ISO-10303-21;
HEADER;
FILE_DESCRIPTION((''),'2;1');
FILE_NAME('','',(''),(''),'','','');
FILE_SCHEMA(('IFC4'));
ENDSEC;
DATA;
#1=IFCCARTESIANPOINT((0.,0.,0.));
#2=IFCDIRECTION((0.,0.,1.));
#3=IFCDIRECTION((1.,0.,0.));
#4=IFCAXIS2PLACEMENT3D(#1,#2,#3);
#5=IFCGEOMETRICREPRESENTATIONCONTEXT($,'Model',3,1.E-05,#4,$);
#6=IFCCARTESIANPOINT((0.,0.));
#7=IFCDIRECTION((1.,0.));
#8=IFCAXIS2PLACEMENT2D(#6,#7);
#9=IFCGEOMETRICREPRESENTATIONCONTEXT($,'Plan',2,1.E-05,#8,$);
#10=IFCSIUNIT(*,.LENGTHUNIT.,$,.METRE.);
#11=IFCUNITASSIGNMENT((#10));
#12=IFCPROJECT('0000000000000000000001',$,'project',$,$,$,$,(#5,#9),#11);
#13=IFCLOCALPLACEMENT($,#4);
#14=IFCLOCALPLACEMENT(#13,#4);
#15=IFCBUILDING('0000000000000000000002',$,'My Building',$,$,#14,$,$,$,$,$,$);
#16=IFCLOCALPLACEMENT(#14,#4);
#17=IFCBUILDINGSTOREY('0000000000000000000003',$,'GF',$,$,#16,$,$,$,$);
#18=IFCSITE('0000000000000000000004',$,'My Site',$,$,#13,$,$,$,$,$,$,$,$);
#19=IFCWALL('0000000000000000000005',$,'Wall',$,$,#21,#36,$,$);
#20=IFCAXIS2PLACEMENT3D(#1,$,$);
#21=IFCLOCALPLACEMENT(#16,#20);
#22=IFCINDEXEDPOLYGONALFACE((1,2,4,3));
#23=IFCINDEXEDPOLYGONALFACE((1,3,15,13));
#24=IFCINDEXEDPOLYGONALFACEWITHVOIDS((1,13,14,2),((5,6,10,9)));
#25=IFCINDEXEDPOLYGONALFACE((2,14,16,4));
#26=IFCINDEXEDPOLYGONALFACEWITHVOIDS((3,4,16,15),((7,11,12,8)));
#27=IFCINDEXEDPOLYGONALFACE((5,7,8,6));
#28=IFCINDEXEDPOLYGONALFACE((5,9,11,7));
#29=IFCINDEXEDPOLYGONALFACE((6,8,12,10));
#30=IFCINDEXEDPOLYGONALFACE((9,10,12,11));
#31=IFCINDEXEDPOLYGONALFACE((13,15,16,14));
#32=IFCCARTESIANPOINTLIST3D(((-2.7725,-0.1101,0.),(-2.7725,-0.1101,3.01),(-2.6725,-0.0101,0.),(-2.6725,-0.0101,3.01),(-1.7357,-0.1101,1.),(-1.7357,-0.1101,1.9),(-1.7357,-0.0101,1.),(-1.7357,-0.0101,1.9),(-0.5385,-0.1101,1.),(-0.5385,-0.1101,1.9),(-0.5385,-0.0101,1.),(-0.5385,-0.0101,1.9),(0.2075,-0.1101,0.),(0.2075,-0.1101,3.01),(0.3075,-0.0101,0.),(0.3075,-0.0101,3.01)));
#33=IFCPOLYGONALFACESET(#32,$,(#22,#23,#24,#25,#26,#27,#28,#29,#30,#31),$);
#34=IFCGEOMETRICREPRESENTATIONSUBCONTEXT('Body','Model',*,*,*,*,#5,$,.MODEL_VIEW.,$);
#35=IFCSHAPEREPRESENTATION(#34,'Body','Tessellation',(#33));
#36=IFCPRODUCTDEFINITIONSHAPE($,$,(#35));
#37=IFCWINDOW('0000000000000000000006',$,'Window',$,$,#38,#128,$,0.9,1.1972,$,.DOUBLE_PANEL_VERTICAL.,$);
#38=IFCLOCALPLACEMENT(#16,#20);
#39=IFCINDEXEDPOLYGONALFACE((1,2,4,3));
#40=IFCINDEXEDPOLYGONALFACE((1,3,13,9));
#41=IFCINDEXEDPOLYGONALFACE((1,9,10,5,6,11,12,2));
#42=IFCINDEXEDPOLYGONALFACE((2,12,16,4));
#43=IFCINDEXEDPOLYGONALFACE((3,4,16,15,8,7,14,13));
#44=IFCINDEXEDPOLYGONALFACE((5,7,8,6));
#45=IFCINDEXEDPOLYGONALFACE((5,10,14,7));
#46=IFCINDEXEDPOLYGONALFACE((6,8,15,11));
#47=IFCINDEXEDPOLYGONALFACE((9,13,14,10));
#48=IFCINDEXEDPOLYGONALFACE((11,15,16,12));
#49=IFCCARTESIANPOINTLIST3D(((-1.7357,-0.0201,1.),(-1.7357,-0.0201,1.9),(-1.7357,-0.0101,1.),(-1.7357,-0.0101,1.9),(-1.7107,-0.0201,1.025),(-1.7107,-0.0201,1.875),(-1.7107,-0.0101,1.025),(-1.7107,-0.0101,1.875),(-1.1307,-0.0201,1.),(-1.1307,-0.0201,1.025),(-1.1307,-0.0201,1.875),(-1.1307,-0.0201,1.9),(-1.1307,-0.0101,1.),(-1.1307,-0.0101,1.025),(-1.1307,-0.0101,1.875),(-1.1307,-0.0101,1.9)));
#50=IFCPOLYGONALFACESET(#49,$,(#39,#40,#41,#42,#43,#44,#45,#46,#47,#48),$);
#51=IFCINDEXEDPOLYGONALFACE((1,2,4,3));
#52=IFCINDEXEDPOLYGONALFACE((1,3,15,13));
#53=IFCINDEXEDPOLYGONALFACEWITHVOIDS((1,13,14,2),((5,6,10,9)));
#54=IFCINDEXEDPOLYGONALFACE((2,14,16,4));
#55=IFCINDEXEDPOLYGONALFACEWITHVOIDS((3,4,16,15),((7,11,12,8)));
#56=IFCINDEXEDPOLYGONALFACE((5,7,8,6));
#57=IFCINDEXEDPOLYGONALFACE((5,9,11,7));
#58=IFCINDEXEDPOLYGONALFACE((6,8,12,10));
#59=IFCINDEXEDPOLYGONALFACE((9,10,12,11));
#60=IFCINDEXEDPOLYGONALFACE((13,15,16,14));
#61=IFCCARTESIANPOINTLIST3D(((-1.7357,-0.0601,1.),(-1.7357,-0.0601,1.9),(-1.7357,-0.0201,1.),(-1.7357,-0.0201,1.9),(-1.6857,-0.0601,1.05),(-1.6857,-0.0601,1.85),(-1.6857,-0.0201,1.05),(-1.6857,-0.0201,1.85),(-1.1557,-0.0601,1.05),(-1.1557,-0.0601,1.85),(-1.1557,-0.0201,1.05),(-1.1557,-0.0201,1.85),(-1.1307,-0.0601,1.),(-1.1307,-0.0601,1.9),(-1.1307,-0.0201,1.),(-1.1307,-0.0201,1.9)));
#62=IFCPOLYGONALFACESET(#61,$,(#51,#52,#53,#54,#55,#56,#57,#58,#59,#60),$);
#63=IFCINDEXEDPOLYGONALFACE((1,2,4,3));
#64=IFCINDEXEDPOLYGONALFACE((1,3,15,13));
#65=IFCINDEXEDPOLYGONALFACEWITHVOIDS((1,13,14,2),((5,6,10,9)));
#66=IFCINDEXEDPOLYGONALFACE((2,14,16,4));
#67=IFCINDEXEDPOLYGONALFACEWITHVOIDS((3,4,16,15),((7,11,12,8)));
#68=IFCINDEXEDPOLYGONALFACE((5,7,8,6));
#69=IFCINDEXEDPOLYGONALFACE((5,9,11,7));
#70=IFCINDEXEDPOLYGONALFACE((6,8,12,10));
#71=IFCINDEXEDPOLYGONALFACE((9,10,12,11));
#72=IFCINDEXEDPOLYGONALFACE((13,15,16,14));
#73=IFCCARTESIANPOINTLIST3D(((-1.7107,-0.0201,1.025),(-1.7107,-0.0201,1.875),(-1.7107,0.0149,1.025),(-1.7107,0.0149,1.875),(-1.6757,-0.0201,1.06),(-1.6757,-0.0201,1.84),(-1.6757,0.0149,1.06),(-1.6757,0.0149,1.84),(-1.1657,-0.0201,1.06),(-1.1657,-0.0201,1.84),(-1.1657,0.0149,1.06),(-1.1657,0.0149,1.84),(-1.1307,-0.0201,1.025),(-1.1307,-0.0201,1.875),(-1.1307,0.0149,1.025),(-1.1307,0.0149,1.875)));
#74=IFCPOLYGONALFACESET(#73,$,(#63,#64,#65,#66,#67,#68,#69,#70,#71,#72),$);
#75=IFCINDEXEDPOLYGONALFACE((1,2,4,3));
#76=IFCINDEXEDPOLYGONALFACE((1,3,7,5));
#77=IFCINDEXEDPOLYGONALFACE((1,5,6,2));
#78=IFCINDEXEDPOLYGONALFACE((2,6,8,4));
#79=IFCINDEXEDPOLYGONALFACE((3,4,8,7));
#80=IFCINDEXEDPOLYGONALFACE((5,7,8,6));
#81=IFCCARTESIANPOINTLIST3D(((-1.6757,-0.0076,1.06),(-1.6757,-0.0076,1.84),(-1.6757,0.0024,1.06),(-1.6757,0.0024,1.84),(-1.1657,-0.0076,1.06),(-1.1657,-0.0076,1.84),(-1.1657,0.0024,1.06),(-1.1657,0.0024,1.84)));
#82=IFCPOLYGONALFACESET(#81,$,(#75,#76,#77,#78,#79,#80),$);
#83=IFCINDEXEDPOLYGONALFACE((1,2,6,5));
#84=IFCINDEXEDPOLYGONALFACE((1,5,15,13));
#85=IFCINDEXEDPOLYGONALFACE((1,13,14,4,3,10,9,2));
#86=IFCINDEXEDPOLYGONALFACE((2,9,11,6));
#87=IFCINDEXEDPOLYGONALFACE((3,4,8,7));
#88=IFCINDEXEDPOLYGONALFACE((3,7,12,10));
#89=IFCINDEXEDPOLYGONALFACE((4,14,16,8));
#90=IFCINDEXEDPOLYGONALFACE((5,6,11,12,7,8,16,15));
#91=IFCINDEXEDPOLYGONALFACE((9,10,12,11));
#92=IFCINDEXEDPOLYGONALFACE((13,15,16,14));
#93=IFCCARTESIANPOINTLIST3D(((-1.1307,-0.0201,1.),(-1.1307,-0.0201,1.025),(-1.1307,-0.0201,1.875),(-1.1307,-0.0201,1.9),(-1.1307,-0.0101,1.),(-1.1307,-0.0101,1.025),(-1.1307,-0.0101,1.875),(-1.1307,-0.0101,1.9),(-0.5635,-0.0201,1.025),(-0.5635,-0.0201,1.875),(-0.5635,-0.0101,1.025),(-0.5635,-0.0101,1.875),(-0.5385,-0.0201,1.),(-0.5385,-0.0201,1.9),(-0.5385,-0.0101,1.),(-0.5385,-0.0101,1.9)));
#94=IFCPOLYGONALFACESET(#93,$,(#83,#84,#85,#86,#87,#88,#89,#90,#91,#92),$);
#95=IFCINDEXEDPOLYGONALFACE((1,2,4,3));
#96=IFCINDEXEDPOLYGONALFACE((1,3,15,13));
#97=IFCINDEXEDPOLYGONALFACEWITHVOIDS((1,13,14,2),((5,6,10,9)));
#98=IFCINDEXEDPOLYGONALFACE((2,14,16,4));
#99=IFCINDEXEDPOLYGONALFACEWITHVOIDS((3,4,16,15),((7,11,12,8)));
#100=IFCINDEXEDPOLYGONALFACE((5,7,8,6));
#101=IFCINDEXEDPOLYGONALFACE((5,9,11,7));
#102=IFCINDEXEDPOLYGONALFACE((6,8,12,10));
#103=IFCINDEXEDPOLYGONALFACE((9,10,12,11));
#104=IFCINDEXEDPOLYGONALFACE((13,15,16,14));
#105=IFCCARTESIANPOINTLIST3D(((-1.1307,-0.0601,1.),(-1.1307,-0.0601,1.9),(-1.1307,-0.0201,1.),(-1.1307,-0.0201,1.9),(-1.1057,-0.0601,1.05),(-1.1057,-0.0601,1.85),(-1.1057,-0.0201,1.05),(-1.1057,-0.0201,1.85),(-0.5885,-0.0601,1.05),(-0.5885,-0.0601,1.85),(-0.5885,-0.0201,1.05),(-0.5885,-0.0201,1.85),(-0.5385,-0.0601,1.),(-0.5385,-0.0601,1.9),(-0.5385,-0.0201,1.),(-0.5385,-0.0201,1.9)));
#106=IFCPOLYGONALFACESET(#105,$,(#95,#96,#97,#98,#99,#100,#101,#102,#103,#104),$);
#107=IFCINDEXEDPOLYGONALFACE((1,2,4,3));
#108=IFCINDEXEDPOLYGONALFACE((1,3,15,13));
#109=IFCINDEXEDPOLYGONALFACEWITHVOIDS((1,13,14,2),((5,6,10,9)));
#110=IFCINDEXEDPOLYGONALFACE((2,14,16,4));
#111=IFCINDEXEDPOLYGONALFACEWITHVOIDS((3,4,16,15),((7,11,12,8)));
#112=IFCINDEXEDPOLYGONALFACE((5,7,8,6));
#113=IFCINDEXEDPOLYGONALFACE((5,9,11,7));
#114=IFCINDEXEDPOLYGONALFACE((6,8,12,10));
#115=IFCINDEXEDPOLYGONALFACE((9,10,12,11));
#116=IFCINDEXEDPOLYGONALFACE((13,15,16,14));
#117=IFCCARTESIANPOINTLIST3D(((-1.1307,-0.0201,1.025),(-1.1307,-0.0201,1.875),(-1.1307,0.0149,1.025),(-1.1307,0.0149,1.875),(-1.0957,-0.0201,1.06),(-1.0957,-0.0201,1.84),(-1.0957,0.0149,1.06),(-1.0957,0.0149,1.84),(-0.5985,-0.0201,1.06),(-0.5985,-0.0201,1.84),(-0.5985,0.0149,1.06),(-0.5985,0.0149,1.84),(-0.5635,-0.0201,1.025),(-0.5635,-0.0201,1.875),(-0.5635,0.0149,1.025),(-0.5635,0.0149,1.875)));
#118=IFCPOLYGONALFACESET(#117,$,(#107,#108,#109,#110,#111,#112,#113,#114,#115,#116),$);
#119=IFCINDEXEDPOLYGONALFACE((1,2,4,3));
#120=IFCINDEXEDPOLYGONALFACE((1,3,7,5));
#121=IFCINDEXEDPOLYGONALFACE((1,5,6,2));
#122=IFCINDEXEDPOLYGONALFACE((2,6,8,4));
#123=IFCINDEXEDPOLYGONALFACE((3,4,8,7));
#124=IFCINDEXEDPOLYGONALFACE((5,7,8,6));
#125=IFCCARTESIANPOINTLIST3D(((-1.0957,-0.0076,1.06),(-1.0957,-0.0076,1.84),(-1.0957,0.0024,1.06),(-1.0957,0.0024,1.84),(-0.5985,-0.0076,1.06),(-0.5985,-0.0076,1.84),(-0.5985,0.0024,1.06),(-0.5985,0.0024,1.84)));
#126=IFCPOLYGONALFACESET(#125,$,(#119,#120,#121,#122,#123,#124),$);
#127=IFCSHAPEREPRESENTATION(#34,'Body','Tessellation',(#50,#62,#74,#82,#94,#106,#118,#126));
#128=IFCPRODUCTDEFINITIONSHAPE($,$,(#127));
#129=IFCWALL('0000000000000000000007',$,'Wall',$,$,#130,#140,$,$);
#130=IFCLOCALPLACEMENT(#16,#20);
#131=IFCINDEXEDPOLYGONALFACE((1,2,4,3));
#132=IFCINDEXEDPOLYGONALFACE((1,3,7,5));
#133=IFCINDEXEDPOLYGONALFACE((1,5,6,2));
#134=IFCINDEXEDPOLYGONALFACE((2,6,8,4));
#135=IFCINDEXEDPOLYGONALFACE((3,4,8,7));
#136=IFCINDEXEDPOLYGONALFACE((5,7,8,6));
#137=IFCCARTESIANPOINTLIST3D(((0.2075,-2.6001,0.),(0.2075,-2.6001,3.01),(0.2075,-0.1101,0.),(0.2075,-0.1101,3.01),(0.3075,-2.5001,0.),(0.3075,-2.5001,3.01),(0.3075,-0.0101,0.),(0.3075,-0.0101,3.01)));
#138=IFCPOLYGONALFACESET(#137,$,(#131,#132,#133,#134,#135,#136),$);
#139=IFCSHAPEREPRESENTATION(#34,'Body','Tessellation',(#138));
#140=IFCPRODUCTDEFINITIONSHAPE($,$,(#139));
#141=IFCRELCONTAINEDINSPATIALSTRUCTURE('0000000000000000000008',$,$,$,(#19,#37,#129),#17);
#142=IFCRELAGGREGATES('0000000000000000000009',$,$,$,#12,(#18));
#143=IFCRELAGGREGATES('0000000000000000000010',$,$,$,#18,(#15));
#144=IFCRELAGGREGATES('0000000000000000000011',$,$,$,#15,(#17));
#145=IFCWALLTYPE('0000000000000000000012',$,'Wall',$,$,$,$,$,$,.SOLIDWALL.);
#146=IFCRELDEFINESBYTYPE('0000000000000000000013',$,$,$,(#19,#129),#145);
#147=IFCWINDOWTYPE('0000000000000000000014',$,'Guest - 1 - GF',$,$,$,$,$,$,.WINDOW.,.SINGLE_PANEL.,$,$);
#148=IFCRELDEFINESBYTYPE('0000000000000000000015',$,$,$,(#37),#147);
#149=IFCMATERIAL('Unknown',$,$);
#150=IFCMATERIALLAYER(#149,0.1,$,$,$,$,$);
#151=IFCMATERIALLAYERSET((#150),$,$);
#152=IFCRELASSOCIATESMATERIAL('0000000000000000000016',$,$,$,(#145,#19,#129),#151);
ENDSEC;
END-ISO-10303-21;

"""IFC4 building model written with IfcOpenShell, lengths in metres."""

from ifc_helpers import new_model, entity, si_unit, frame, origin_with_axes, origin_2d_with_axis, place, context, subcontext, project, spatial, line, indexed_curve, outline, extrude, shape, source, transform, mapped, material, layer, layer_set, layer_usage, type_object, type_shapes, element, fill, save


model = new_model("IFC4")

# Units and contexts
model_context = context("Model", 3, precision=1e-05, world=origin_with_axes())
plan_context = context("Plan", 2, precision=1e-05, world=origin_2d_with_axis())
body_context_1 = subcontext(model_context, "Body", "Model", "MODEL_VIEW")
body_context_2 = subcontext(plan_context, "Body", "Plan", "PLAN_VIEW")
ifc_project = project(units=[si_unit("LENGTHUNIT", "METRE")], contexts=[model_context, plan_context])

# Site, building, storey
site_placement = place(None, origin_with_axes())
site = spatial("IfcSite", under=ifc_project, at=site_placement, Name="My Site")
building_placement = place(site_placement, origin_with_axes())
building = spatial("IfcBuilding", under=site, at=building_placement, Name="My Building")
storey_placement = place(building_placement, origin_with_axes())
storey = spatial("IfcBuildingStorey", under=building, at=storey_placement, Name="GF")

# Shared definitions
ifc_material_1 = material(Name="Unknown")

# Shared definitions
ifc_layer_1 = layer(ifc_material_1, 0.1)
ifc_layer_set_1 = layer_set([ifc_layer_1])
wall_type = type_object("IfcWallType", Name="Wall", PredefinedType="SOLIDWALL", material=ifc_layer_set_1)

# Wall, opening, window
ifc_layer_usage_1 = layer_usage(ifc_layer_set_1, "AXIS2", "POSITIVE", 0.0)
wall_1_placement = place(storey_placement, frame((-2.7725, -0.1101, 0.0), z_axis=(0.0, 0.0, 1.0), x_axis=(1.0, 0.0, 0.0)))
wall_1 = element("IfcWall", 1, at=wall_1_placement, inside=storey, type_object=wall_type, material=ifc_layer_usage_1, Name="Wall", context=body_context_1, shape_type="SweptSolid", body=[
    extrude(outline(indexed_curve([(0.0, 0.0), (0.1, 0.1), (3.08, 0.1), (2.98, 0.0)], segments=[line(1, 2, 3, 4, 1)])), origin_with_axes(), (0.0, 0.0, 1.0), 3.01),
])
shared_shape_1 = source(origin_with_axes(), body_context_1, "Body", "SweptSolid", [
    extrude(outline(indexed_curve([(0.0, 0.0), (1.1972, 0.0), (1.1972, 0.9), (0.0, 0.9)], segments=[line(1, 2, 3, 4, 1)])), frame((0.0, -0.6, 0.0), z_axis=(0.0, -1.0, 0.0), x_axis=(1.0, 0.0, 0.0)), (0.0, 0.0, -1.0), 1.2),
])
opening_1_placement = place(wall_1_placement, frame((1.0369, 0.0, 1.0), z_axis=(0.0, 0.0, 1.0), x_axis=(1.0, 0.0, 0.0)))
opening_1 = element("IfcOpeningElement", 2, at=opening_1_placement, cuts=wall_1, PredefinedType="OPENING", context=body_context_1, shape_type="MappedRepresentation", body=[
    mapped(shared_shape_1, transform((0.0, 0.0, 0.0), x_axis=(1.0, 0.0, 0.0), y_axis=(0.0, 1.0, 0.0), z_axis=(0.0, 0.0, 1.0), scale=1.0)),
])
window_type_1 = type_object("IfcWindowType", Name="Guest - 1 - GF", PartitioningType="SINGLE_PANEL", PredefinedType="WINDOW")
shared_shape_2 = source(origin_with_axes(), body_context_1, "Body", "SweptSolid", [
    extrude(outline(indexed_curve([(0.605, 0.0), (0.0, 0.0), (0.0, 0.9), (0.605, 0.9), (0.605, 0.875), (0.025, 0.875), (0.025, 0.025), (0.605, 0.025)], segments=[line(1, 2, 3, 4, 5, 6, 7, 8, 1)])), frame((0.0, 0.09, 0.0), z_axis=(0.0, -1.0, 0.0), x_axis=(1.0, 0.0, 0.0)), (0.0, 0.0, -1.0), 0.01),
    extrude(outline(indexed_curve([(0.0, 0.0), (0.605, 0.0), (0.605, 0.9), (0.0, 0.9)], segments=[line(1, 2, 3, 4, 1)]), holes=[indexed_curve([(0.05, 0.05), (0.58, 0.05), (0.58, 0.85), (0.05, 0.85)], segments=[line(1, 2, 3, 4, 1)])]), frame((0.0, 0.05, 0.0), z_axis=(0.0, -1.0, 0.0), x_axis=(1.0, 0.0, 0.0)), (0.0, 0.0, -1.0), 0.04),
    extrude(outline(indexed_curve([(0.0, 0.0), (0.58, 0.0), (0.58, 0.85), (0.0, 0.85)], segments=[line(1, 2, 3, 4, 1)]), holes=[indexed_curve([(0.035, 0.035), (0.545, 0.035), (0.545, 0.815), (0.035, 0.815)], segments=[line(1, 2, 3, 4, 1)])]), frame((0.025, 0.09, 0.025), z_axis=(0.0, -1.0, 0.0), x_axis=(1.0, 0.0, 0.0)), (0.0, 0.0, -1.0), 0.035),
    extrude(outline(indexed_curve([(0.035, 0.035), (0.545, 0.035), (0.545, 0.815), (0.035, 0.815)], segments=[line(1, 2, 3, 4, 1)])), frame((0.025, 0.1025, 0.025), z_axis=(0.0, -1.0, 0.0), x_axis=(1.0, 0.0, 0.0)), (0.0, 0.0, -1.0), 0.01),
    extrude(outline(indexed_curve([(0.0, 0.9), (0.5922, 0.9), (0.5922, 0.0), (0.0, 0.0), (0.0, 0.025), (0.5672, 0.025), (0.5672, 0.875), (0.0, 0.875)], segments=[line(1, 2, 3, 4, 5, 6, 7, 8, 1)])), frame((0.605, 0.09, 0.0), z_axis=(0.0, -1.0, 0.0), x_axis=(1.0, 0.0, 0.0)), (0.0, 0.0, -1.0), 0.01),
    extrude(outline(indexed_curve([(0.0, 0.0), (0.5922, 0.0), (0.5922, 0.9), (0.0, 0.9)], segments=[line(1, 2, 3, 4, 1)]), holes=[indexed_curve([(0.025, 0.05), (0.5422, 0.05), (0.5422, 0.85), (0.025, 0.85)], segments=[line(1, 2, 3, 4, 1)])]), frame((0.605, 0.05, 0.0), z_axis=(0.0, -1.0, 0.0), x_axis=(1.0, 0.0, 0.0)), (0.0, 0.0, -1.0), 0.04),
    extrude(outline(indexed_curve([(0.0, 0.0), (0.5672, 0.0), (0.5672, 0.85), (0.0, 0.85)], segments=[line(1, 2, 3, 4, 1)]), holes=[indexed_curve([(0.035, 0.035), (0.5322, 0.035), (0.5322, 0.815), (0.035, 0.815)], segments=[line(1, 2, 3, 4, 1)])]), frame((0.605, 0.09, 0.025), z_axis=(0.0, -1.0, 0.0), x_axis=(1.0, 0.0, 0.0)), (0.0, 0.0, -1.0), 0.035),
    extrude(outline(indexed_curve([(0.035, 0.035), (0.5322, 0.035), (0.5322, 0.815), (0.035, 0.815)], segments=[line(1, 2, 3, 4, 1)])), frame((0.605, 0.1025, 0.025), z_axis=(0.0, -1.0, 0.0), x_axis=(1.0, 0.0, 0.0)), (0.0, 0.0, -1.0), 0.01),
])
shared_shape_3 = source(origin_with_axes(), body_context_2, "Body", "Curve2D", [
    entity("IfcIndexedPolyCurve", entity("IfcCartesianPointList2D", [[0.05, 0.05], [0.58, 0.05]])),
    entity("IfcIndexedPolyCurve", entity("IfcCartesianPointList2D", [[0.0, 0.1], [0.025, 0.1], [0.025, 0.09], [0.05, 0.09], [0.05, 0.05], [0.0, 0.05]]), [entity("IfcLineIndex", [1, 2, 3, 4, 5, 6, 1])]),
    entity("IfcIndexedPolyCurve", entity("IfcCartesianPointList2D", [[0.605, 0.1], [0.605, 0.1], [0.605, 0.09], [0.58, 0.09], [0.58, 0.05], [0.605, 0.05]])),
    entity("IfcIndexedPolyCurve", entity("IfcCartesianPointList2D", [[0.025, 0.09], [0.06, 0.09], [0.06, 0.125], [0.025, 0.125]]), [entity("IfcLineIndex", [1, 2, 3, 4, 1])]),
    entity("IfcIndexedPolyCurve", entity("IfcCartesianPointList2D", [[0.605, 0.09], [0.57, 0.09], [0.57, 0.125], [0.605, 0.125]]), [entity("IfcLineIndex", [1, 2, 3, 4, 1])]),
    entity("IfcIndexedPolyCurve", entity("IfcCartesianPointList2D", [[0.06, 0.09], [0.57, 0.09]])),
    entity("IfcIndexedPolyCurve", entity("IfcCartesianPointList2D", [[0.06, 0.125], [0.57, 0.125]])),
    entity("IfcIndexedPolyCurve", entity("IfcCartesianPointList2D", [[0.06, 0.1075], [0.57, 0.1075]])),
    entity("IfcIndexedPolyCurve", entity("IfcCartesianPointList2D", [[0.63, 0.05], [1.1472, 0.05]])),
    entity("IfcIndexedPolyCurve", entity("IfcCartesianPointList2D", [[0.605, 0.1], [0.605, 0.1], [0.605, 0.09], [0.63, 0.09], [0.63, 0.05], [0.605, 0.05]])),
    entity("IfcIndexedPolyCurve", entity("IfcCartesianPointList2D", [[1.1972, 0.1], [1.1722, 0.1], [1.1722, 0.09], [1.1472, 0.09], [1.1472, 0.05], [1.1972, 0.05]]), [entity("IfcLineIndex", [1, 2, 3, 4, 5, 6, 1])]),
    entity("IfcIndexedPolyCurve", entity("IfcCartesianPointList2D", [[0.605, 0.09], [0.64, 0.09], [0.64, 0.125], [0.605, 0.125]]), [entity("IfcLineIndex", [1, 2, 3, 4, 1])]),
    entity("IfcIndexedPolyCurve", entity("IfcCartesianPointList2D", [[1.1722, 0.09], [1.1372, 0.09], [1.1372, 0.125], [1.1722, 0.125]]), [entity("IfcLineIndex", [1, 2, 3, 4, 1])]),
    entity("IfcIndexedPolyCurve", entity("IfcCartesianPointList2D", [[0.64, 0.09], [1.1372, 0.09]])),
    entity("IfcIndexedPolyCurve", entity("IfcCartesianPointList2D", [[0.64, 0.125], [1.1372, 0.125]])),
    entity("IfcIndexedPolyCurve", entity("IfcCartesianPointList2D", [[0.64, 0.1075], [1.1372, 0.1075]])),
])
type_shapes(window_type_1, [shared_shape_2, shared_shape_3])
window_1_placement = place(opening_1_placement, origin_with_axes())
window_1 = element("IfcWindow", 3, at=window_1_placement, inside=storey, type_object=window_type_1, Name="Window", OverallHeight=0.9, OverallWidth=1.1972, PartitioningType="DOUBLE_PANEL_VERTICAL", shapes=[
    shape(body_context_1, "Body", "MappedRepresentation", [mapped(shared_shape_2, transform((0.0, 0.0, 0.0), x_axis=(1.0, 0.0, 0.0), y_axis=(0.0, 1.0, 0.0), z_axis=(0.0, 0.0, 1.0), scale=1.0))]),
    shape(body_context_2, "Body", "MappedRepresentation", [mapped(shared_shape_3, transform((0.0, 0.0, 0.0), x_axis=(1.0, 0.0, 0.0), y_axis=(0.0, 1.0, 0.0), z_axis=(0.0, 0.0, 1.0), scale=1.0))]),
])
fill(opening_1, window_1)

# Wall
ifc_layer_usage_2 = layer_usage(ifc_layer_set_1, "AXIS2", "POSITIVE", 0.0)
wall_2_placement = place(storey_placement, frame((0.2075, -0.1101, 0.0), z_axis=(0.0, 0.0, 1.0), x_axis=(0.0, -1.0, 0.0)))
element("IfcWall", 4, at=wall_2_placement, inside=storey, type_object=wall_type, material=ifc_layer_usage_2, Name="Wall", context=body_context_1, shape_type="SweptSolid", body=[
    extrude(outline(indexed_curve([(0.0, 0.0), (-0.1, 0.1), (2.39, 0.1), (2.49, 0.0)], segments=[line(1, 2, 3, 4, 1)])), origin_with_axes(), (0.0, 0.0, 1.0), 3.01),
])

save(model, "model.ifc")
